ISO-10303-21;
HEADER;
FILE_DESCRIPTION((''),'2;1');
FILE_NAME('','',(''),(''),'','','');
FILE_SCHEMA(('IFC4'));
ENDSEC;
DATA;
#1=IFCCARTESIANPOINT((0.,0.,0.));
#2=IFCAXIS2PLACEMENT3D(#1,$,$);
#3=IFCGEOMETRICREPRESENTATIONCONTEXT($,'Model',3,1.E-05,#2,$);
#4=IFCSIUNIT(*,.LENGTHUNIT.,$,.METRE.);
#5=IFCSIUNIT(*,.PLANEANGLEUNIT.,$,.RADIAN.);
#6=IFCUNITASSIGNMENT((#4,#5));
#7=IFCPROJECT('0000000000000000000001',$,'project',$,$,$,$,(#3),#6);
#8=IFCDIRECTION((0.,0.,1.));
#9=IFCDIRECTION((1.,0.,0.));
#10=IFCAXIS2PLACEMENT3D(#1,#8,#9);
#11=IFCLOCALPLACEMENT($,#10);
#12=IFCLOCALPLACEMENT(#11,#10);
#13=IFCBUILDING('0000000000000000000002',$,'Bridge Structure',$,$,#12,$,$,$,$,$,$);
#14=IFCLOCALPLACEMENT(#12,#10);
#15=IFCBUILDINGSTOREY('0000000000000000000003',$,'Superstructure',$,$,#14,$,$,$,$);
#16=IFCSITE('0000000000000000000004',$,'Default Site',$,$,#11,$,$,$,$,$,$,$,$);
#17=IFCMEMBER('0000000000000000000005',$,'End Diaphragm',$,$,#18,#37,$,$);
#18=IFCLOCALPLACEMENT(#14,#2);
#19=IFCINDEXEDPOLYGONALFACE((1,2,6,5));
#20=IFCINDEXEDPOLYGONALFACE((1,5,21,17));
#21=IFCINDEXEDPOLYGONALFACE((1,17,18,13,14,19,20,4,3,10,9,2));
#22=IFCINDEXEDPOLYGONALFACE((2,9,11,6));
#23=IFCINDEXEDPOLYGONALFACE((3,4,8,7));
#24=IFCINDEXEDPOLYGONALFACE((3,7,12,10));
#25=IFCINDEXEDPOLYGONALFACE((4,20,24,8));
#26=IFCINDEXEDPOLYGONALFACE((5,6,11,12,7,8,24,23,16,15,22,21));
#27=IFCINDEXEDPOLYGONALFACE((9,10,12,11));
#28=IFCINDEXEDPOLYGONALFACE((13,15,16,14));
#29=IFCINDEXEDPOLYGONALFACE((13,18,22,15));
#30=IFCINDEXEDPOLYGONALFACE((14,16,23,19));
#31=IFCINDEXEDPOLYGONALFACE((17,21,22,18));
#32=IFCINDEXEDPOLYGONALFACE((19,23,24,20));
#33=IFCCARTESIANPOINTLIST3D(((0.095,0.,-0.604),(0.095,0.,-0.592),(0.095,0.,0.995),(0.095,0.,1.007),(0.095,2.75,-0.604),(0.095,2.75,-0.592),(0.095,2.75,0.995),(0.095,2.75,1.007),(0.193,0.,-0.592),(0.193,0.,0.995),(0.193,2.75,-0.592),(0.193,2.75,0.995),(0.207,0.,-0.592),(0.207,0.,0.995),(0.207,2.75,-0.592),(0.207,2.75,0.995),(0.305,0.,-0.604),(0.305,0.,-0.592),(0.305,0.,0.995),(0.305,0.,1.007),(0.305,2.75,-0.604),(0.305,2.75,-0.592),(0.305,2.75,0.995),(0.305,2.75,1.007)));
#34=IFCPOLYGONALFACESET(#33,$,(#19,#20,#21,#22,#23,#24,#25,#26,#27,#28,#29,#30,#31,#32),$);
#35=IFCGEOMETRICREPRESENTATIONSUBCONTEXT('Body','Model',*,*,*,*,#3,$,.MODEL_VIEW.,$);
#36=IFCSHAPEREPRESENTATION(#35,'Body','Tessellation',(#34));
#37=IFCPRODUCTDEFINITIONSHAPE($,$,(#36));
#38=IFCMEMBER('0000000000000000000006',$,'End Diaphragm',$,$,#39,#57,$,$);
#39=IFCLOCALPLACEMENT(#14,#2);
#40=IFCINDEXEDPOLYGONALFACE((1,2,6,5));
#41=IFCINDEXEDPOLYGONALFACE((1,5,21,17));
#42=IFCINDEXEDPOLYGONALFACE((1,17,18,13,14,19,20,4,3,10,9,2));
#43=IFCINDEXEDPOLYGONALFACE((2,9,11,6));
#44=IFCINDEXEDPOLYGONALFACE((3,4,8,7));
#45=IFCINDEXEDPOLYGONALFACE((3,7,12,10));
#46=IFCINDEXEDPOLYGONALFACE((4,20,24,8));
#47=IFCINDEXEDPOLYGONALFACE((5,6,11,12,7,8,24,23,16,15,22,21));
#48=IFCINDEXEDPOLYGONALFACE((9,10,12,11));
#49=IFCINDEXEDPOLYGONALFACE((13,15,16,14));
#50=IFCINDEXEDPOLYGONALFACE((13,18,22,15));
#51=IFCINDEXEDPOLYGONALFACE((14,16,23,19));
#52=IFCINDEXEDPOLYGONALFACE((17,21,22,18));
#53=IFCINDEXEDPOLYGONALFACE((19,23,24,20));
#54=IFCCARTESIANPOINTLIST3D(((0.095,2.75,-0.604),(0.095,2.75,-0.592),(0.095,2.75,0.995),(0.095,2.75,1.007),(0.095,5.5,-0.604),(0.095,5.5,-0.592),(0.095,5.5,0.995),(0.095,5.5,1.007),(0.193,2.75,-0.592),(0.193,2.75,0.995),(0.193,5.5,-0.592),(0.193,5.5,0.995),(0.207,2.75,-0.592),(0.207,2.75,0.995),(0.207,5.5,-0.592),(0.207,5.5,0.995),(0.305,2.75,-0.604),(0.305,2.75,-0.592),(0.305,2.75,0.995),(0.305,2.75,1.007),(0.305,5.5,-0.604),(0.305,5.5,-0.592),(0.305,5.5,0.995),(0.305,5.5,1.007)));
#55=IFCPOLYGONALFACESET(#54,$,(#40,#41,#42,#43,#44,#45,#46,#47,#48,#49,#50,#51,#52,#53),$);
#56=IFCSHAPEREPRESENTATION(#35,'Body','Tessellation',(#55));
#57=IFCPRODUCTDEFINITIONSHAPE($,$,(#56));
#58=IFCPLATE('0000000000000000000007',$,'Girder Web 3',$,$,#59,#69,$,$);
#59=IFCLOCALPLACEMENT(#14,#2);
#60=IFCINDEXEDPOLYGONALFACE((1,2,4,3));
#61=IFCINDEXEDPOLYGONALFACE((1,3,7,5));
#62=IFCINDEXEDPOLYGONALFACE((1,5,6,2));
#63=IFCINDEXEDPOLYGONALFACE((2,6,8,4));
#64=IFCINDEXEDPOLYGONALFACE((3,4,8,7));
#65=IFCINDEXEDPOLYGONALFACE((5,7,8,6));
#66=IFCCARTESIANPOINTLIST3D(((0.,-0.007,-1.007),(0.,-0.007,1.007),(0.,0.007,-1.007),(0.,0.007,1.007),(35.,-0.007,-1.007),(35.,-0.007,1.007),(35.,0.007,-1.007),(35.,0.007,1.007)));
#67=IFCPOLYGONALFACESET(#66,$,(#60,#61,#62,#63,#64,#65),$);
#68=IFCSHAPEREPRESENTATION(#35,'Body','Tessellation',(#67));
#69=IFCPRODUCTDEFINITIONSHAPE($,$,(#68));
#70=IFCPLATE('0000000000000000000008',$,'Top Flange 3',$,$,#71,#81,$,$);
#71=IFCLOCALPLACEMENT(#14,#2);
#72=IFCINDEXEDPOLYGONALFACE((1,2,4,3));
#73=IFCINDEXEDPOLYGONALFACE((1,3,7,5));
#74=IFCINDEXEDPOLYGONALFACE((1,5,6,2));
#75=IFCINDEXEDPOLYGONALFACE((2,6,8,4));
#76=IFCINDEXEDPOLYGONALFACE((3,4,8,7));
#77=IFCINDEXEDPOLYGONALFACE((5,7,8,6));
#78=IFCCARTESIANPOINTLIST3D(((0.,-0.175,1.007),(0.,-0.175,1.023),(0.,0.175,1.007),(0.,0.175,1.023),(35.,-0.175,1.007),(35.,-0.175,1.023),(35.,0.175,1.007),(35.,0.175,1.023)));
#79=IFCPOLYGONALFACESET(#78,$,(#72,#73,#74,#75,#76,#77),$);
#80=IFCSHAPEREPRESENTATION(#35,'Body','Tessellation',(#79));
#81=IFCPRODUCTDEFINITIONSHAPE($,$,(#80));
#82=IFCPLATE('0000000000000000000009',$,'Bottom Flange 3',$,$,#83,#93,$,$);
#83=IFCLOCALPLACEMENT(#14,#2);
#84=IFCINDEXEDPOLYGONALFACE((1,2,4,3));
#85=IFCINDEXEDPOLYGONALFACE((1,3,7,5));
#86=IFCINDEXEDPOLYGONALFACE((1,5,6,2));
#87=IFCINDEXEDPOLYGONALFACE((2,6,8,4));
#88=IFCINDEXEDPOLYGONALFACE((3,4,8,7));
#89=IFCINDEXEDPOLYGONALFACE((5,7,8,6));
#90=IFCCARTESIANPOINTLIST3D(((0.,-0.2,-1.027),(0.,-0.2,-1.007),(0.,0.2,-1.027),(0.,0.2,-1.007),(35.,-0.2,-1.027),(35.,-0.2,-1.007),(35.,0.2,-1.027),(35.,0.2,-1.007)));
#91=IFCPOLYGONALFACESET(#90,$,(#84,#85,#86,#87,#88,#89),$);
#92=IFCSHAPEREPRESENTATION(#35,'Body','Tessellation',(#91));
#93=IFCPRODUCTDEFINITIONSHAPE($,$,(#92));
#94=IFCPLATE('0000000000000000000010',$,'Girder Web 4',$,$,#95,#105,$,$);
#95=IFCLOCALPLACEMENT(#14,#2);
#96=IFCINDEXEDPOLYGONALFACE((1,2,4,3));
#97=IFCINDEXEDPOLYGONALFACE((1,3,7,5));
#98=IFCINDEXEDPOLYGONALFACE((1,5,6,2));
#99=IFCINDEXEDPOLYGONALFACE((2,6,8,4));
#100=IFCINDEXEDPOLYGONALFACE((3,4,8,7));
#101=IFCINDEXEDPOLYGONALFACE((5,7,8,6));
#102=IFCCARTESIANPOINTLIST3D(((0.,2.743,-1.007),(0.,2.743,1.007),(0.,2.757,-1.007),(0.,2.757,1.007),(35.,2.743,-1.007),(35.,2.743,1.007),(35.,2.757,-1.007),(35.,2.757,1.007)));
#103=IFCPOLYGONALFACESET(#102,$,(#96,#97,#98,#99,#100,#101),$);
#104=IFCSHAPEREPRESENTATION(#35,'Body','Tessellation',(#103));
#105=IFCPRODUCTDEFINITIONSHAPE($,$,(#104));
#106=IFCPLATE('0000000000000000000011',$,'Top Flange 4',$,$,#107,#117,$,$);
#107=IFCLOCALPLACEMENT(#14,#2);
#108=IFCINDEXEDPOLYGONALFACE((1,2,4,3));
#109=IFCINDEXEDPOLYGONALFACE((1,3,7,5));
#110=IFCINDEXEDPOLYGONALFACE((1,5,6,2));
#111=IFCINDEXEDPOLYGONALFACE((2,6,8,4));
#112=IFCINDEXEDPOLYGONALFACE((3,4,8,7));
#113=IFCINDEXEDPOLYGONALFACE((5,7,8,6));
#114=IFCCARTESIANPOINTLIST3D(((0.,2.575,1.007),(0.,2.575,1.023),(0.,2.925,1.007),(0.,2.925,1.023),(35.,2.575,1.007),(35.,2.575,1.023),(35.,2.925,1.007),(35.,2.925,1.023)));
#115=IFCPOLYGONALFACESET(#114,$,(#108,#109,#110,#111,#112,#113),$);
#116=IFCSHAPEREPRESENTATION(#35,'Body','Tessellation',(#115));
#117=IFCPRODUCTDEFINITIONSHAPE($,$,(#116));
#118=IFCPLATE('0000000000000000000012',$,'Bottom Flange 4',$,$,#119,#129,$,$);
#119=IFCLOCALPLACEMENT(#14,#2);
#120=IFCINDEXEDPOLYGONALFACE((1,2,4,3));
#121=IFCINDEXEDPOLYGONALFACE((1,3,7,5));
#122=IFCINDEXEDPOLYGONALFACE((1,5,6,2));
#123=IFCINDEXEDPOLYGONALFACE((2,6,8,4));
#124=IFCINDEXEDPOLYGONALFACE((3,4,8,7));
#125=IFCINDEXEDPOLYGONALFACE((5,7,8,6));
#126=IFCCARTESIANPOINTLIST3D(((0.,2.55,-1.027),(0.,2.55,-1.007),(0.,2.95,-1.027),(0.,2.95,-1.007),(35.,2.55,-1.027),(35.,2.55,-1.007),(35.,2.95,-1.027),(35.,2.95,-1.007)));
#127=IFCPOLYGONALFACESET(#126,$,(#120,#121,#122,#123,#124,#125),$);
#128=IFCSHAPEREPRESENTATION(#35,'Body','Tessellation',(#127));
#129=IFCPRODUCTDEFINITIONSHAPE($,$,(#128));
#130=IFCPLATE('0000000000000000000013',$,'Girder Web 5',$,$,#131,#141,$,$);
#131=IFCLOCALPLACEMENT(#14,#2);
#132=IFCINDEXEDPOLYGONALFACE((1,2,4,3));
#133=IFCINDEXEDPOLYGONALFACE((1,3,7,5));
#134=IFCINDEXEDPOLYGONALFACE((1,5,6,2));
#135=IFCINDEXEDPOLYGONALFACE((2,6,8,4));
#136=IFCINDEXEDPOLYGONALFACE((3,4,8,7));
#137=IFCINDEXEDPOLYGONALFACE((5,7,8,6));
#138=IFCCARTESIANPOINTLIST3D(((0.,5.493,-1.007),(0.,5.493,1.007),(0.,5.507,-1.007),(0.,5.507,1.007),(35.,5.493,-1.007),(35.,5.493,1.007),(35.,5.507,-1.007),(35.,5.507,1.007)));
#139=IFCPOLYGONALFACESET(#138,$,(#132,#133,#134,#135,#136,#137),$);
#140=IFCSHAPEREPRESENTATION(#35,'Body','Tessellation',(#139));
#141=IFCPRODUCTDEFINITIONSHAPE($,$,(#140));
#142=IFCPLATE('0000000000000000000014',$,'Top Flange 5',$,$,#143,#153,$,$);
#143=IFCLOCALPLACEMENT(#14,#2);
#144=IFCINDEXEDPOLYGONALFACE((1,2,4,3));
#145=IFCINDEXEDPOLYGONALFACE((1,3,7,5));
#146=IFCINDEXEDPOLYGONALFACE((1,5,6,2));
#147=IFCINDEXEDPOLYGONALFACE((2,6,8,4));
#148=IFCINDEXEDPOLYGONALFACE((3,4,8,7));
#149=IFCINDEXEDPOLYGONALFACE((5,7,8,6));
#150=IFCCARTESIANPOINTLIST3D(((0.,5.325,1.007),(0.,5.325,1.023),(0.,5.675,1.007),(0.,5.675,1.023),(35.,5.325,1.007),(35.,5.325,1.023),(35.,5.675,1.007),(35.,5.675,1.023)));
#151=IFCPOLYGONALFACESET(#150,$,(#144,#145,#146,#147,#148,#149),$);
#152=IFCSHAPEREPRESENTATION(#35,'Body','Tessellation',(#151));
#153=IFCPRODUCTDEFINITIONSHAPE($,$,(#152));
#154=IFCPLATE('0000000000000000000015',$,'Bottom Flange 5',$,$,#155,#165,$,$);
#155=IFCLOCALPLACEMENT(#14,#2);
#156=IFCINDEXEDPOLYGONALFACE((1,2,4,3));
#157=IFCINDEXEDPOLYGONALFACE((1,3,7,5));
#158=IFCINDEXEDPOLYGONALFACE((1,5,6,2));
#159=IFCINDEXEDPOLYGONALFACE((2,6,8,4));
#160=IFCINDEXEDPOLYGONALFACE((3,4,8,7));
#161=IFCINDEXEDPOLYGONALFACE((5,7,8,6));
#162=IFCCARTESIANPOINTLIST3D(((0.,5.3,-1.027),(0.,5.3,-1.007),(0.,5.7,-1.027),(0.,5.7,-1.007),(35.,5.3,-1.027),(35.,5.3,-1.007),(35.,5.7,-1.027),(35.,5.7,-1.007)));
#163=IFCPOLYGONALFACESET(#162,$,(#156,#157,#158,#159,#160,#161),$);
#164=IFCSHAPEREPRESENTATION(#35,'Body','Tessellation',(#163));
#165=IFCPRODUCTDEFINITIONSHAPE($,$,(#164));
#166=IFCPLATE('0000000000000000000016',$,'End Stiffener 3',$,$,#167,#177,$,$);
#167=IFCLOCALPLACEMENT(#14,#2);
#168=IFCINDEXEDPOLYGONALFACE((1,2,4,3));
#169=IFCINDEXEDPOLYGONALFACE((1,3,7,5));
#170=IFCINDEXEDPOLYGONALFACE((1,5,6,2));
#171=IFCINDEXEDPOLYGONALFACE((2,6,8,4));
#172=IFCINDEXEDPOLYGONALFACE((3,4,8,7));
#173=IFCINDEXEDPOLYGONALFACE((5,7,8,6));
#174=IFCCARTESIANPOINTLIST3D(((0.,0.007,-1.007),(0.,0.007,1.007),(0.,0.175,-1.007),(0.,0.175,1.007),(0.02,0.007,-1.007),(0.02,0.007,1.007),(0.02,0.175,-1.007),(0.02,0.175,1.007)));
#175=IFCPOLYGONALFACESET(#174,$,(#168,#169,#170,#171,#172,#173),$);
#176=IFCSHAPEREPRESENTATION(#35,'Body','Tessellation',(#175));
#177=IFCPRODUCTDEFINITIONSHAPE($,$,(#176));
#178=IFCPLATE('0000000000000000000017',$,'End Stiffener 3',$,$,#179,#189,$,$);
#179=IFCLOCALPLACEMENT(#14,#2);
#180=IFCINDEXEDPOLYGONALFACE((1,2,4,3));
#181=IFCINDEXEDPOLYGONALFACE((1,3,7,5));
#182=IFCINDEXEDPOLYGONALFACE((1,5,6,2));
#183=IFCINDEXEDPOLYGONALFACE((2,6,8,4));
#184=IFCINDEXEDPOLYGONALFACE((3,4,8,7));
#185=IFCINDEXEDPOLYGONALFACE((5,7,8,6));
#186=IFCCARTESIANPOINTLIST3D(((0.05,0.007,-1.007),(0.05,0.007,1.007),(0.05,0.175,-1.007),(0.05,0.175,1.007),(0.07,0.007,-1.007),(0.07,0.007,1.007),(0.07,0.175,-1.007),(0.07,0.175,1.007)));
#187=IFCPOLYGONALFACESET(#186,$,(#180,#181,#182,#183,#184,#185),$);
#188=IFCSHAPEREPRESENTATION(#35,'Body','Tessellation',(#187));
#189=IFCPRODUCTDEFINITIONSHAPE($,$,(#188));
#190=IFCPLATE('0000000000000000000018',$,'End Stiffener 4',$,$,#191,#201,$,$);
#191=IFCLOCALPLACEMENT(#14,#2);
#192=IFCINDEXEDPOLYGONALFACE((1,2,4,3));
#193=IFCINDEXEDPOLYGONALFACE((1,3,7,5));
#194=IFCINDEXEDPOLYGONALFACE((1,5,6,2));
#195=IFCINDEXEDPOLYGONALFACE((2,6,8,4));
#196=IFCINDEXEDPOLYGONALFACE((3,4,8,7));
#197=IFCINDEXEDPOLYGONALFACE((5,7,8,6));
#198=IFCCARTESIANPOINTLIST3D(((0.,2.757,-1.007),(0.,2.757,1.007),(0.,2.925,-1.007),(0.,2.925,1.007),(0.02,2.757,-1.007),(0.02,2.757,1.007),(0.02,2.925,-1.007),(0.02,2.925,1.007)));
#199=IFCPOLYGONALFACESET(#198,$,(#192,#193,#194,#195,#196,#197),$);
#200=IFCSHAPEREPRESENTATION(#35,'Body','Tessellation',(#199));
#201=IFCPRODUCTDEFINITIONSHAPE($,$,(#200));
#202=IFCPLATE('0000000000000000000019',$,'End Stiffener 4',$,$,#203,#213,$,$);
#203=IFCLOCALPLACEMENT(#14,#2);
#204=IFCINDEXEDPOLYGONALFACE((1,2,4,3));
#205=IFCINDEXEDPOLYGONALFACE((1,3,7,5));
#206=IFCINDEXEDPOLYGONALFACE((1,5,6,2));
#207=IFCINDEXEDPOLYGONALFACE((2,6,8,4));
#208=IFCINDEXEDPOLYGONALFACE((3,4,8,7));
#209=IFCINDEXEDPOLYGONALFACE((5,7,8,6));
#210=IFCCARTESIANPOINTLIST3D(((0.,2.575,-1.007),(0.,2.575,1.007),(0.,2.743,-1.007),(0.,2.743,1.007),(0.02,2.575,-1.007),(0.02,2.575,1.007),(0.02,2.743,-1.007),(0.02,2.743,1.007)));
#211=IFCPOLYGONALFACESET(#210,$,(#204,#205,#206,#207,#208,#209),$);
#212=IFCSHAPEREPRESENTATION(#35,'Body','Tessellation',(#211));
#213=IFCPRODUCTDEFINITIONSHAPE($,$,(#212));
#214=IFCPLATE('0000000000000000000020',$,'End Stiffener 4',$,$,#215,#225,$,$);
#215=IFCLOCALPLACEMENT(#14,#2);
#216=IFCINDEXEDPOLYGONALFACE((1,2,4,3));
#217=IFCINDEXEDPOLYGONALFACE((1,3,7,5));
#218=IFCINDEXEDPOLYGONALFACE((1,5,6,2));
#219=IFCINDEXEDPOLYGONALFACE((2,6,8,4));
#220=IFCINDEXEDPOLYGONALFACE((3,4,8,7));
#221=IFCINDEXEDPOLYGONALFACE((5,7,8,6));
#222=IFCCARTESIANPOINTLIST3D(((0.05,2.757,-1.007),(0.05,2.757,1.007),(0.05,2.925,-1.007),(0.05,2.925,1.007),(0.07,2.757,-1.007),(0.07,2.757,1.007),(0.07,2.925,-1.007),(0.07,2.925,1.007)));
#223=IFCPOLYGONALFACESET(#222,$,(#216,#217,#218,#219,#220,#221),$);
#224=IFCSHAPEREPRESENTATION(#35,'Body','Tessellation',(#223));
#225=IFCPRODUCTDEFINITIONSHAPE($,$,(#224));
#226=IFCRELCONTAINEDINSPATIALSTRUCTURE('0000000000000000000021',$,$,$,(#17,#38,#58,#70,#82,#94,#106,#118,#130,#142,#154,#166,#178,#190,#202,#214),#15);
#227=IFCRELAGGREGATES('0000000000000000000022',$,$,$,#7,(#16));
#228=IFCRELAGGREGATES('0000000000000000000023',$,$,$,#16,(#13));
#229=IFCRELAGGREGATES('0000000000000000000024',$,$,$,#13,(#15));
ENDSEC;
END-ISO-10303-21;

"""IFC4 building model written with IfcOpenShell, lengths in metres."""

from ifc_helpers import new_model, si_unit, frame, origin, origin_with_axes, origin_2d_with_axis, place, context, subcontext, project, spatial, rectangle, i_section, extrude, element, save


model = new_model("IFC4")

# Units and contexts
model_context = context("Model", 3, precision=1e-05, world=origin())
body_context = subcontext(model_context, "Body", "Model", "MODEL_VIEW")
ifc_project = project(units=[si_unit("LENGTHUNIT", "METRE"), si_unit("PLANEANGLEUNIT", "RADIAN")], contexts=[model_context])

# Site, building, storey
site_placement = place(None, origin_with_axes())
site = spatial("IfcSite", under=ifc_project, at=site_placement, Name="Default Site")
building_placement = place(site_placement, origin_with_axes())
building = spatial("IfcBuilding", under=site, at=building_placement, Name="Bridge Structure")
storey_placement = place(building_placement, origin_with_axes())
storey = spatial("IfcBuildingStorey", under=building, at=storey_placement, Name="Superstructure")

# Members
for number, where, z_axis, x_axis, name in (
    (1, (0.2, 0.0, 0.2015), (0.0, 1.0, 0.0), (-1.0, 0.0, 0.0), "End Diaphragm"),
    (2, (0.2, 2.75, 0.2015), (0.0, 1.0, 0.0), (-1.0, 0.0, 0.0), "End Diaphragm"),
):
    element("IfcMember", number, at=place(storey_placement, frame(where, z_axis=z_axis, x_axis=x_axis)), inside=storey, Name=name, context=body_context, shape_type="SweptSolid", body=[
        extrude(i_section(OverallWidth=0.21, OverallDepth=1.611, WebThickness=0.014, FlangeThickness=0.012, at=origin_2d_with_axis()), origin_with_axes(), (0.0, 0.0, 1.0), 2.75),
    ])

# Plates
plate_1_placement = place(storey_placement, frame((0.0, 0.0, 0.0), z_axis=(1.0, 0.0, 0.0), x_axis=(0.0, 1.0, 0.0)))
element("IfcPlate", 3, at=plate_1_placement, inside=storey, Name="Girder Web 3", context=body_context, shape_type="SweptSolid", body=[
    extrude(rectangle(XDim=0.014, YDim=2.014, at=origin_2d_with_axis()), origin_with_axes(), (0.0, 0.0, 1.0), 35.0),
])
plate_2_placement = place(storey_placement, frame((0.0, 0.0, 1.015), z_axis=(1.0, 0.0, 0.0), x_axis=(0.0, 1.0, 0.0)))
element("IfcPlate", 4, at=plate_2_placement, inside=storey, Name="Top Flange 3", context=body_context, shape_type="SweptSolid", body=[
    extrude(rectangle(XDim=0.35, YDim=0.016, at=origin_2d_with_axis()), origin_with_axes(), (0.0, 0.0, 1.0), 35.0),
])
plate_3_placement = place(storey_placement, frame((0.0, 0.0, -1.017), z_axis=(1.0, 0.0, 0.0), x_axis=(0.0, 1.0, 0.0)))
element("IfcPlate", 5, at=plate_3_placement, inside=storey, Name="Bottom Flange 3", context=body_context, shape_type="SweptSolid", body=[
    extrude(rectangle(XDim=0.4, YDim=0.02, at=origin_2d_with_axis()), origin_with_axes(), (0.0, 0.0, 1.0), 35.0),
])
plate_4_placement = place(storey_placement, frame((0.0, 2.75, 0.0), z_axis=(1.0, 0.0, 0.0), x_axis=(0.0, 1.0, 0.0)))
element("IfcPlate", 6, at=plate_4_placement, inside=storey, Name="Girder Web 4", context=body_context, shape_type="SweptSolid", body=[
    extrude(rectangle(XDim=0.014, YDim=2.014, at=origin_2d_with_axis()), origin_with_axes(), (0.0, 0.0, 1.0), 35.0),
])
plate_5_placement = place(storey_placement, frame((0.0, 2.75, 1.015), z_axis=(1.0, 0.0, 0.0), x_axis=(0.0, 1.0, 0.0)))
element("IfcPlate", 7, at=plate_5_placement, inside=storey, Name="Top Flange 4", context=body_context, shape_type="SweptSolid", body=[
    extrude(rectangle(XDim=0.35, YDim=0.016, at=origin_2d_with_axis()), origin_with_axes(), (0.0, 0.0, 1.0), 35.0),
])
plate_6_placement = place(storey_placement, frame((0.0, 2.75, -1.017), z_axis=(1.0, 0.0, 0.0), x_axis=(0.0, 1.0, 0.0)))
element("IfcPlate", 8, at=plate_6_placement, inside=storey, Name="Bottom Flange 4", context=body_context, shape_type="SweptSolid", body=[
    extrude(rectangle(XDim=0.4, YDim=0.02, at=origin_2d_with_axis()), origin_with_axes(), (0.0, 0.0, 1.0), 35.0),
])
plate_7_placement = place(storey_placement, frame((0.0, 5.5, 0.0), z_axis=(1.0, 0.0, 0.0), x_axis=(0.0, 1.0, 0.0)))
element("IfcPlate", 9, at=plate_7_placement, inside=storey, Name="Girder Web 5", context=body_context, shape_type="SweptSolid", body=[
    extrude(rectangle(XDim=0.014, YDim=2.014, at=origin_2d_with_axis()), origin_with_axes(), (0.0, 0.0, 1.0), 35.0),
])
plate_8_placement = place(storey_placement, frame((0.0, 5.5, 1.015), z_axis=(1.0, 0.0, 0.0), x_axis=(0.0, 1.0, 0.0)))
element("IfcPlate", 10, at=plate_8_placement, inside=storey, Name="Top Flange 5", context=body_context, shape_type="SweptSolid", body=[
    extrude(rectangle(XDim=0.35, YDim=0.016, at=origin_2d_with_axis()), origin_with_axes(), (0.0, 0.0, 1.0), 35.0),
])
plate_9_placement = place(storey_placement, frame((0.0, 5.5, -1.017), z_axis=(1.0, 0.0, 0.0), x_axis=(0.0, 1.0, 0.0)))
element("IfcPlate", 11, at=plate_9_placement, inside=storey, Name="Bottom Flange 5", context=body_context, shape_type="SweptSolid", body=[
    extrude(rectangle(XDim=0.4, YDim=0.02, at=origin_2d_with_axis()), origin_with_axes(), (0.0, 0.0, 1.0), 35.0),
])
for number, where, z_axis, x_axis, name in (
    (12, (0.01, 0.091, -1.007), (0.0, 0.0, 1.0), (1.0, 0.0, 0.0), "End Stiffener 3"),
    (13, (0.06, 0.091, -1.007), (0.0, 0.0, 1.0), (1.0, 0.0, 0.0), "End Stiffener 3"),
    (14, (0.01, 2.841, -1.007), (0.0, 0.0, 1.0), (1.0, 0.0, 0.0), "End Stiffener 4"),
    (15, (0.01, 2.659, -1.007), (0.0, 0.0, 1.0), (1.0, 0.0, 0.0), "End Stiffener 4"),
    (16, (0.06, 2.841, -1.007), (0.0, 0.0, 1.0), (1.0, 0.0, 0.0), "End Stiffener 4"),
):
    element("IfcPlate", number, at=place(storey_placement, frame(where, z_axis=z_axis, x_axis=x_axis)), inside=storey, Name=name, context=body_context, shape_type="SweptSolid", body=[
        extrude(rectangle(XDim=0.02, YDim=0.168, at=origin_2d_with_axis()), origin_with_axes(), (0.0, 0.0, 1.0), 2.014),
    ])

save(model, "model.ifc")
